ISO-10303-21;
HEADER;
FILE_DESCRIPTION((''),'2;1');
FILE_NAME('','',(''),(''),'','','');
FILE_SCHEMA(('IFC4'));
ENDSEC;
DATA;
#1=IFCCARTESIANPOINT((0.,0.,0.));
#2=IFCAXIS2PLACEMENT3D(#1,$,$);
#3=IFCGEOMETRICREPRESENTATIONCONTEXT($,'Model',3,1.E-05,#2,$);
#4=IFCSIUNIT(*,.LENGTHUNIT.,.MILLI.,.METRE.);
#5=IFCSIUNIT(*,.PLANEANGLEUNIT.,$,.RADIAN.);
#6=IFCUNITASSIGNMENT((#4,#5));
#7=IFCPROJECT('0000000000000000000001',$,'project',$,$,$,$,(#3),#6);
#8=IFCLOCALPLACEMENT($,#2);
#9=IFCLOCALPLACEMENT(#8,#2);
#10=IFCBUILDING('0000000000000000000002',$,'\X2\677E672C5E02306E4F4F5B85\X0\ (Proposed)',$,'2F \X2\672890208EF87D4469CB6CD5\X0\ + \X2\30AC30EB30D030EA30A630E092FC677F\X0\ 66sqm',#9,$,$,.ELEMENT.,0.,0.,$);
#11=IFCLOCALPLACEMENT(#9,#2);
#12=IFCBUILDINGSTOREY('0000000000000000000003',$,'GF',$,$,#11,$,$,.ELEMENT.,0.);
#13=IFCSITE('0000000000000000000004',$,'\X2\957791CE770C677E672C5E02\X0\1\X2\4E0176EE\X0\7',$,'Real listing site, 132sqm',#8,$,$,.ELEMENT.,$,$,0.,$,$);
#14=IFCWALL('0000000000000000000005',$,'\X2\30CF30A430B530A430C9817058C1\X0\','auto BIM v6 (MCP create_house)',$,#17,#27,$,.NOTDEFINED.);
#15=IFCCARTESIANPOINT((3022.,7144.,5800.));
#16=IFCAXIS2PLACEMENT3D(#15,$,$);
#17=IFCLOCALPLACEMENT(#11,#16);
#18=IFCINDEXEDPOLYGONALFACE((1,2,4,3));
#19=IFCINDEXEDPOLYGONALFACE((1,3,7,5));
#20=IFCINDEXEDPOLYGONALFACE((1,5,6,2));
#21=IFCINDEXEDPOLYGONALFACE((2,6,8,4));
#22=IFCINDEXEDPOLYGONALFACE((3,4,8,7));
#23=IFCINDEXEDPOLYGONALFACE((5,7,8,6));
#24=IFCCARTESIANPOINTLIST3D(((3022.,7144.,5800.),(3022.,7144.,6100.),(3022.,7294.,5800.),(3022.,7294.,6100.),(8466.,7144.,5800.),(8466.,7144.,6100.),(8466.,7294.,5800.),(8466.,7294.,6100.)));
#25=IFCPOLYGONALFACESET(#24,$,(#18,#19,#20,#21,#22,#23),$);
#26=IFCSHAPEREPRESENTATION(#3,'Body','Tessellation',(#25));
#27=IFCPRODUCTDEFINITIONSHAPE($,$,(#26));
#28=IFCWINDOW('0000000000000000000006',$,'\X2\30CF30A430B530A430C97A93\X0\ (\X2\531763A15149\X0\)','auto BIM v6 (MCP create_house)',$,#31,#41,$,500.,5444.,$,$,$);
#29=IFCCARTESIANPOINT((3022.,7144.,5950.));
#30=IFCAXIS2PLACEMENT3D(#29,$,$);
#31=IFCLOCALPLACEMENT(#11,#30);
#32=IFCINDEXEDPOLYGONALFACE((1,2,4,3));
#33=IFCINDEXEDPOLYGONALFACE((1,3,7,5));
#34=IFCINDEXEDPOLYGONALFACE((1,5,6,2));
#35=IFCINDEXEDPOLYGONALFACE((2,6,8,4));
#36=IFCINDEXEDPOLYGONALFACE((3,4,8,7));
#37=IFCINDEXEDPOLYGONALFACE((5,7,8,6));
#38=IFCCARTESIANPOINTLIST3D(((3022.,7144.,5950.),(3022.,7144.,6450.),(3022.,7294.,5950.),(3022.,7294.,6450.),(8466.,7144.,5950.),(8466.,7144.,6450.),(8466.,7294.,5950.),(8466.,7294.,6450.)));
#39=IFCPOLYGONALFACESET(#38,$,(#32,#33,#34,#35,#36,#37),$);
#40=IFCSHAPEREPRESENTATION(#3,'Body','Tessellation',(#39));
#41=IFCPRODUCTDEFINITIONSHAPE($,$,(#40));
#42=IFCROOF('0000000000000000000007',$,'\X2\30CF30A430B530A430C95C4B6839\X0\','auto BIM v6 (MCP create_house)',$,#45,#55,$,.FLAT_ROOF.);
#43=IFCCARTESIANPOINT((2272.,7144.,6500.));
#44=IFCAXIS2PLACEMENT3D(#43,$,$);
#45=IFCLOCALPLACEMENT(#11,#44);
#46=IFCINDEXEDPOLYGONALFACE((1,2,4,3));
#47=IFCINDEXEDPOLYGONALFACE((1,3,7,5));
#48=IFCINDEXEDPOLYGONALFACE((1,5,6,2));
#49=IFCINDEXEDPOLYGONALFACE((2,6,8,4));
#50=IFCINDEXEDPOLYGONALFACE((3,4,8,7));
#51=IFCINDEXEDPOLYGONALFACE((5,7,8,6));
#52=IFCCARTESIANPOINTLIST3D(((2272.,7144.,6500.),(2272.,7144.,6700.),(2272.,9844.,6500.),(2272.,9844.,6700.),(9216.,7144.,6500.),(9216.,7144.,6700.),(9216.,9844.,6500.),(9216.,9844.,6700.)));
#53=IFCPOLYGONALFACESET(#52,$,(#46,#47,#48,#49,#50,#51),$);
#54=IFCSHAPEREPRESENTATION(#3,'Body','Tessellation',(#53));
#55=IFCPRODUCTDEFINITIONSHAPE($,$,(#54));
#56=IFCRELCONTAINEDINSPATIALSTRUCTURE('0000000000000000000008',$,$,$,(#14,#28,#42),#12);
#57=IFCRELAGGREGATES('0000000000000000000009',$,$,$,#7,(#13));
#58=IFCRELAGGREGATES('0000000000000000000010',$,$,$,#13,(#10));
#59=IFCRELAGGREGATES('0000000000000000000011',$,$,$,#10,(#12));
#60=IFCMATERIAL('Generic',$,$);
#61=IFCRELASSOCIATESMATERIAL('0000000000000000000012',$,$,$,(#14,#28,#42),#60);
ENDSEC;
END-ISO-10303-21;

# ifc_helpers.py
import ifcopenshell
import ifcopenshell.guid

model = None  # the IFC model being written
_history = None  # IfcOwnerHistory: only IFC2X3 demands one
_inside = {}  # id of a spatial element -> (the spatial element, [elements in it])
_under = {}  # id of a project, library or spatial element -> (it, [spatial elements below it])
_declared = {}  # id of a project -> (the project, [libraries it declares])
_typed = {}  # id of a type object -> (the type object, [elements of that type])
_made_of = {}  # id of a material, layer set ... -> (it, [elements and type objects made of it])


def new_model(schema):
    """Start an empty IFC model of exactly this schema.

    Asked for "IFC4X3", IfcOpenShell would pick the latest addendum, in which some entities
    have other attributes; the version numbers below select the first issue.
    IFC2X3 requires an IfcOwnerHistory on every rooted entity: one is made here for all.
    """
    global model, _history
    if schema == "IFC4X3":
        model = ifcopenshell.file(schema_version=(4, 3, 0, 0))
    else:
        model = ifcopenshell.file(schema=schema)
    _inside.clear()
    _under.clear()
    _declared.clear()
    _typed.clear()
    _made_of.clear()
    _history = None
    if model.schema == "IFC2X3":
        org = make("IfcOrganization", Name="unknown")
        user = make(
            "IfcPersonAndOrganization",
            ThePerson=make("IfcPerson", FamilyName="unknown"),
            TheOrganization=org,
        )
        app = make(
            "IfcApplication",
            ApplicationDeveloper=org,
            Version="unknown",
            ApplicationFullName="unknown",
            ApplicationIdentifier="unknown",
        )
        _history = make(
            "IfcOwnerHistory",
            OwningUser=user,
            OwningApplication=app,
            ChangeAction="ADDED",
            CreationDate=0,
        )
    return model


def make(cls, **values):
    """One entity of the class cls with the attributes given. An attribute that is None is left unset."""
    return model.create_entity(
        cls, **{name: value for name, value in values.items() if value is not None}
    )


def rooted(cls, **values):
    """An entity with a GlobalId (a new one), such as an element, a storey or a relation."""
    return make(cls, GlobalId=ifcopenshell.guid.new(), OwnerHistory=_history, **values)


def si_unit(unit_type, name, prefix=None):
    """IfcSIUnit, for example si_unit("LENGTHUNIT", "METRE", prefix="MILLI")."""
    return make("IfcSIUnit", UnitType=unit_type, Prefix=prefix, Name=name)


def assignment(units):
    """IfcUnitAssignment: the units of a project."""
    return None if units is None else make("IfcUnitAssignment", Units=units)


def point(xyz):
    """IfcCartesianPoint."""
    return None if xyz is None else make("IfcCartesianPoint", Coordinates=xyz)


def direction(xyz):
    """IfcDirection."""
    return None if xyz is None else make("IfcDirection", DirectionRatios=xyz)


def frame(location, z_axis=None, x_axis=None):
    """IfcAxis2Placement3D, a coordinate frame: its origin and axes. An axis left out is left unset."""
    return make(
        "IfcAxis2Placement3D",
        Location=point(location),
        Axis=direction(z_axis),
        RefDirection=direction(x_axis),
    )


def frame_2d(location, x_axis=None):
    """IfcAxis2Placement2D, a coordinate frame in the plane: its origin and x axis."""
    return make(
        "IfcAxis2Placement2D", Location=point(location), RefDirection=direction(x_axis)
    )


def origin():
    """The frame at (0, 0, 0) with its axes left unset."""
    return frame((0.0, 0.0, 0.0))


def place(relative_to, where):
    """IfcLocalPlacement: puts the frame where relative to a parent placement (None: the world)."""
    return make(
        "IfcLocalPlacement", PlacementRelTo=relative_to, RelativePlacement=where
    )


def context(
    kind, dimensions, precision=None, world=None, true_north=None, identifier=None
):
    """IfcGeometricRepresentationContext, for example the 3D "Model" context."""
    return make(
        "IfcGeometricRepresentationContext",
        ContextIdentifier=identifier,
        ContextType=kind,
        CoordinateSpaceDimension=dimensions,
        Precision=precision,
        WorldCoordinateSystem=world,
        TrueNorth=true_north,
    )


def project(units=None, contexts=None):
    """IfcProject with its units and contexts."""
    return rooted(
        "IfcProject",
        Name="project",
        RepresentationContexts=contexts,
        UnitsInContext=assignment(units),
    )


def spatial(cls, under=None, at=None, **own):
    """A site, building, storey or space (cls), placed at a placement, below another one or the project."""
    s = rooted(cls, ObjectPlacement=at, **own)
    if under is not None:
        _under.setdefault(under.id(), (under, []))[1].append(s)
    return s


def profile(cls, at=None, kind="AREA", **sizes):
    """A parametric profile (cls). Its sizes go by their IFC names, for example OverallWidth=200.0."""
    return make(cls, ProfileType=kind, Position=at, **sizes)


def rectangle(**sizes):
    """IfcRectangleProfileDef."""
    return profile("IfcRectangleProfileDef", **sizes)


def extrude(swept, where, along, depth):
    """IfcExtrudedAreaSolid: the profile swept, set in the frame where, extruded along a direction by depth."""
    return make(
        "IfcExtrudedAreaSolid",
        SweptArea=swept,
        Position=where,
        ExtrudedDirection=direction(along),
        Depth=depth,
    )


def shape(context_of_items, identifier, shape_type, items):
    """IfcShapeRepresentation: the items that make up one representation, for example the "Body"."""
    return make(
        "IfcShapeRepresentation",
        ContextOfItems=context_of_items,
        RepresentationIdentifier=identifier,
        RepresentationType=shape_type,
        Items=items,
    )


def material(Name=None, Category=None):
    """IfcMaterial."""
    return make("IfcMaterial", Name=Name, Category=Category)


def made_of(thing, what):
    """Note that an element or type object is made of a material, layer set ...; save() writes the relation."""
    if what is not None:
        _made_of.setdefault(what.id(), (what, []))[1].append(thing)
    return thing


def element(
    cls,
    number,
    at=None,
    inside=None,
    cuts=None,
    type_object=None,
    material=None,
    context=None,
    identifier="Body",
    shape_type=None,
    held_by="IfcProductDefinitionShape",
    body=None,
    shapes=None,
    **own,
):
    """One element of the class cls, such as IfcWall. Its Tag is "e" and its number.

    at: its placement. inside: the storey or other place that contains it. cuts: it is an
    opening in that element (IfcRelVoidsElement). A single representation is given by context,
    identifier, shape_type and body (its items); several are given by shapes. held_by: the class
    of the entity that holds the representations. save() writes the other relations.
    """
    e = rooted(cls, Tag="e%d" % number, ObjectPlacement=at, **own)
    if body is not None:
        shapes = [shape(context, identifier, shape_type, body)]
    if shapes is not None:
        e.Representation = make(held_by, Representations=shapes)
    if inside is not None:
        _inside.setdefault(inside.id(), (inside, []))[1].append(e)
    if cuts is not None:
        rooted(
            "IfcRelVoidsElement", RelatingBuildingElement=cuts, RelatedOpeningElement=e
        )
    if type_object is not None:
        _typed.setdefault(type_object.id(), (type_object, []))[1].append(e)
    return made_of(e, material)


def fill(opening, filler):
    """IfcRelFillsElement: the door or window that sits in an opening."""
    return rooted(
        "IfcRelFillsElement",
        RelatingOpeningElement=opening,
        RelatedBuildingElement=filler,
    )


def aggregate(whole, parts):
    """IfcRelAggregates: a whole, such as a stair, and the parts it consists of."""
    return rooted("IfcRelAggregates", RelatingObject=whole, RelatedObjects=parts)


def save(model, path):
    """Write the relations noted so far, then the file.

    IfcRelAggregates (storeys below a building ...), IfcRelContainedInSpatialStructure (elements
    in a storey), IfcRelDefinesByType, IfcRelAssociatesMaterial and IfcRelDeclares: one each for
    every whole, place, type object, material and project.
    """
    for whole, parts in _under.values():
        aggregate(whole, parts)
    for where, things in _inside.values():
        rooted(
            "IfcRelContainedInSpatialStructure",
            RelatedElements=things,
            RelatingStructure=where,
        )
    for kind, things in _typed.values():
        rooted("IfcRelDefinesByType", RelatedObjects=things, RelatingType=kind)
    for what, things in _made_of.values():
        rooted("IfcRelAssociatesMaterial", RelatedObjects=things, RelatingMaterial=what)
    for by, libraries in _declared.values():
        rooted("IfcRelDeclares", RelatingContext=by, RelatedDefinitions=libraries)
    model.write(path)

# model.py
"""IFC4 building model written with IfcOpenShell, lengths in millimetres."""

from ifc_helpers import new_model, si_unit, frame, frame_2d, origin, place, context, project, spatial, rectangle, extrude, material, element, fill, save


model = new_model("IFC4")

# Units and contexts
model_context = context("Model", 3, precision=1e-05, world=origin())
ifc_project = project(units=[si_unit("LENGTHUNIT", "METRE", prefix="MILLI"), si_unit("PLANEANGLEUNIT", "RADIAN")], contexts=[model_context])

# Site, building, storey
site_placement = place(None, origin())
site = spatial("IfcSite", under=ifc_project, at=site_placement, Name="長野県松本市1丁目7", ObjectType="Real listing site, 132sqm", CompositionType="ELEMENT", RefElevation=0.0)
building_placement = place(site_placement, origin())
building = spatial("IfcBuilding", under=site, at=building_placement, Name="松本市の住宅 (Proposed)", ObjectType="2F 木造軸組構法 + ガルバリウム鋼板 66sqm", CompositionType="ELEMENT", ElevationOfRefHeight=0.0, ElevationOfTerrain=0.0)
storey_placement = place(building_placement, origin())
storey = spatial("IfcBuildingStorey", under=building, at=storey_placement, Name="GF", CompositionType="ELEMENT", Elevation=0.0)

# Shared definitions
ifc_material = material(Name="Generic")

# Wall, opening, window
wall_1_placement = place(storey_placement, frame((3022.0, 7144.0, 5800.0)))
wall_1 = element("IfcWall", 1, at=wall_1_placement, inside=storey, material=ifc_material, Name="ハイサイド腰壁", Description="auto BIM v6 (MCP create_house)", PredefinedType="NOTDEFINED", context=model_context, shape_type="SweptSolid", body=[
    extrude(rectangle(XDim=5444.0, YDim=150.0, at=frame_2d((2722.0, 75.0))), frame((3022.0, 7144.0, 5800.0)), (0.0, 0.0, 1.0), 700.0),
])
opening_1_placement = place(storey_placement, frame((3022.0, 7144.0, 5950.0)))
opening_1 = element("IfcOpeningElement", 2, at=opening_1_placement, cuts=wall_1, PredefinedType="NOTDEFINED", context=model_context, shape_type="SweptSolid", body=[
    extrude(rectangle(XDim=5444.0, YDim=150.0, at=frame_2d((2722.0, 75.0))), frame((3022.0, 7144.0, 5950.0)), (0.0, 0.0, 1.0), 500.0),
])
window_1_placement = place(storey_placement, frame((3022.0, 7144.0, 5950.0)))
window_1 = element("IfcWindow", 3, at=window_1_placement, inside=storey, material=ifc_material, Name="ハイサイド窓 (北採光)", Description="auto BIM v6 (MCP create_house)", OverallHeight=500.0, OverallWidth=5444.0, context=model_context, shape_type="SweptSolid", body=[
    extrude(rectangle(XDim=5444.0, YDim=150.0, at=frame_2d((2722.0, 75.0))), frame((3022.0, 7144.0, 5950.0)), (0.0, 0.0, 1.0), 500.0),
])
fill(opening_1, window_1)

# Roof
roof_placement = place(storey_placement, frame((2272.0, 7144.0, 6500.0)))
element("IfcRoof", 4, at=roof_placement, inside=storey, material=ifc_material, Name="ハイサイド屋根", Description="auto BIM v6 (MCP create_house)", PredefinedType="FLAT_ROOF", context=model_context, shape_type="SweptSolid", body=[
    extrude(rectangle(XDim=6944.0, YDim=2700.0, at=frame_2d((3472.0, 1350.0))), frame((2272.0, 7144.0, 6500.0)), (0.0, 0.0, 1.0), 200.0),
])

save(model, "model.ifc")
